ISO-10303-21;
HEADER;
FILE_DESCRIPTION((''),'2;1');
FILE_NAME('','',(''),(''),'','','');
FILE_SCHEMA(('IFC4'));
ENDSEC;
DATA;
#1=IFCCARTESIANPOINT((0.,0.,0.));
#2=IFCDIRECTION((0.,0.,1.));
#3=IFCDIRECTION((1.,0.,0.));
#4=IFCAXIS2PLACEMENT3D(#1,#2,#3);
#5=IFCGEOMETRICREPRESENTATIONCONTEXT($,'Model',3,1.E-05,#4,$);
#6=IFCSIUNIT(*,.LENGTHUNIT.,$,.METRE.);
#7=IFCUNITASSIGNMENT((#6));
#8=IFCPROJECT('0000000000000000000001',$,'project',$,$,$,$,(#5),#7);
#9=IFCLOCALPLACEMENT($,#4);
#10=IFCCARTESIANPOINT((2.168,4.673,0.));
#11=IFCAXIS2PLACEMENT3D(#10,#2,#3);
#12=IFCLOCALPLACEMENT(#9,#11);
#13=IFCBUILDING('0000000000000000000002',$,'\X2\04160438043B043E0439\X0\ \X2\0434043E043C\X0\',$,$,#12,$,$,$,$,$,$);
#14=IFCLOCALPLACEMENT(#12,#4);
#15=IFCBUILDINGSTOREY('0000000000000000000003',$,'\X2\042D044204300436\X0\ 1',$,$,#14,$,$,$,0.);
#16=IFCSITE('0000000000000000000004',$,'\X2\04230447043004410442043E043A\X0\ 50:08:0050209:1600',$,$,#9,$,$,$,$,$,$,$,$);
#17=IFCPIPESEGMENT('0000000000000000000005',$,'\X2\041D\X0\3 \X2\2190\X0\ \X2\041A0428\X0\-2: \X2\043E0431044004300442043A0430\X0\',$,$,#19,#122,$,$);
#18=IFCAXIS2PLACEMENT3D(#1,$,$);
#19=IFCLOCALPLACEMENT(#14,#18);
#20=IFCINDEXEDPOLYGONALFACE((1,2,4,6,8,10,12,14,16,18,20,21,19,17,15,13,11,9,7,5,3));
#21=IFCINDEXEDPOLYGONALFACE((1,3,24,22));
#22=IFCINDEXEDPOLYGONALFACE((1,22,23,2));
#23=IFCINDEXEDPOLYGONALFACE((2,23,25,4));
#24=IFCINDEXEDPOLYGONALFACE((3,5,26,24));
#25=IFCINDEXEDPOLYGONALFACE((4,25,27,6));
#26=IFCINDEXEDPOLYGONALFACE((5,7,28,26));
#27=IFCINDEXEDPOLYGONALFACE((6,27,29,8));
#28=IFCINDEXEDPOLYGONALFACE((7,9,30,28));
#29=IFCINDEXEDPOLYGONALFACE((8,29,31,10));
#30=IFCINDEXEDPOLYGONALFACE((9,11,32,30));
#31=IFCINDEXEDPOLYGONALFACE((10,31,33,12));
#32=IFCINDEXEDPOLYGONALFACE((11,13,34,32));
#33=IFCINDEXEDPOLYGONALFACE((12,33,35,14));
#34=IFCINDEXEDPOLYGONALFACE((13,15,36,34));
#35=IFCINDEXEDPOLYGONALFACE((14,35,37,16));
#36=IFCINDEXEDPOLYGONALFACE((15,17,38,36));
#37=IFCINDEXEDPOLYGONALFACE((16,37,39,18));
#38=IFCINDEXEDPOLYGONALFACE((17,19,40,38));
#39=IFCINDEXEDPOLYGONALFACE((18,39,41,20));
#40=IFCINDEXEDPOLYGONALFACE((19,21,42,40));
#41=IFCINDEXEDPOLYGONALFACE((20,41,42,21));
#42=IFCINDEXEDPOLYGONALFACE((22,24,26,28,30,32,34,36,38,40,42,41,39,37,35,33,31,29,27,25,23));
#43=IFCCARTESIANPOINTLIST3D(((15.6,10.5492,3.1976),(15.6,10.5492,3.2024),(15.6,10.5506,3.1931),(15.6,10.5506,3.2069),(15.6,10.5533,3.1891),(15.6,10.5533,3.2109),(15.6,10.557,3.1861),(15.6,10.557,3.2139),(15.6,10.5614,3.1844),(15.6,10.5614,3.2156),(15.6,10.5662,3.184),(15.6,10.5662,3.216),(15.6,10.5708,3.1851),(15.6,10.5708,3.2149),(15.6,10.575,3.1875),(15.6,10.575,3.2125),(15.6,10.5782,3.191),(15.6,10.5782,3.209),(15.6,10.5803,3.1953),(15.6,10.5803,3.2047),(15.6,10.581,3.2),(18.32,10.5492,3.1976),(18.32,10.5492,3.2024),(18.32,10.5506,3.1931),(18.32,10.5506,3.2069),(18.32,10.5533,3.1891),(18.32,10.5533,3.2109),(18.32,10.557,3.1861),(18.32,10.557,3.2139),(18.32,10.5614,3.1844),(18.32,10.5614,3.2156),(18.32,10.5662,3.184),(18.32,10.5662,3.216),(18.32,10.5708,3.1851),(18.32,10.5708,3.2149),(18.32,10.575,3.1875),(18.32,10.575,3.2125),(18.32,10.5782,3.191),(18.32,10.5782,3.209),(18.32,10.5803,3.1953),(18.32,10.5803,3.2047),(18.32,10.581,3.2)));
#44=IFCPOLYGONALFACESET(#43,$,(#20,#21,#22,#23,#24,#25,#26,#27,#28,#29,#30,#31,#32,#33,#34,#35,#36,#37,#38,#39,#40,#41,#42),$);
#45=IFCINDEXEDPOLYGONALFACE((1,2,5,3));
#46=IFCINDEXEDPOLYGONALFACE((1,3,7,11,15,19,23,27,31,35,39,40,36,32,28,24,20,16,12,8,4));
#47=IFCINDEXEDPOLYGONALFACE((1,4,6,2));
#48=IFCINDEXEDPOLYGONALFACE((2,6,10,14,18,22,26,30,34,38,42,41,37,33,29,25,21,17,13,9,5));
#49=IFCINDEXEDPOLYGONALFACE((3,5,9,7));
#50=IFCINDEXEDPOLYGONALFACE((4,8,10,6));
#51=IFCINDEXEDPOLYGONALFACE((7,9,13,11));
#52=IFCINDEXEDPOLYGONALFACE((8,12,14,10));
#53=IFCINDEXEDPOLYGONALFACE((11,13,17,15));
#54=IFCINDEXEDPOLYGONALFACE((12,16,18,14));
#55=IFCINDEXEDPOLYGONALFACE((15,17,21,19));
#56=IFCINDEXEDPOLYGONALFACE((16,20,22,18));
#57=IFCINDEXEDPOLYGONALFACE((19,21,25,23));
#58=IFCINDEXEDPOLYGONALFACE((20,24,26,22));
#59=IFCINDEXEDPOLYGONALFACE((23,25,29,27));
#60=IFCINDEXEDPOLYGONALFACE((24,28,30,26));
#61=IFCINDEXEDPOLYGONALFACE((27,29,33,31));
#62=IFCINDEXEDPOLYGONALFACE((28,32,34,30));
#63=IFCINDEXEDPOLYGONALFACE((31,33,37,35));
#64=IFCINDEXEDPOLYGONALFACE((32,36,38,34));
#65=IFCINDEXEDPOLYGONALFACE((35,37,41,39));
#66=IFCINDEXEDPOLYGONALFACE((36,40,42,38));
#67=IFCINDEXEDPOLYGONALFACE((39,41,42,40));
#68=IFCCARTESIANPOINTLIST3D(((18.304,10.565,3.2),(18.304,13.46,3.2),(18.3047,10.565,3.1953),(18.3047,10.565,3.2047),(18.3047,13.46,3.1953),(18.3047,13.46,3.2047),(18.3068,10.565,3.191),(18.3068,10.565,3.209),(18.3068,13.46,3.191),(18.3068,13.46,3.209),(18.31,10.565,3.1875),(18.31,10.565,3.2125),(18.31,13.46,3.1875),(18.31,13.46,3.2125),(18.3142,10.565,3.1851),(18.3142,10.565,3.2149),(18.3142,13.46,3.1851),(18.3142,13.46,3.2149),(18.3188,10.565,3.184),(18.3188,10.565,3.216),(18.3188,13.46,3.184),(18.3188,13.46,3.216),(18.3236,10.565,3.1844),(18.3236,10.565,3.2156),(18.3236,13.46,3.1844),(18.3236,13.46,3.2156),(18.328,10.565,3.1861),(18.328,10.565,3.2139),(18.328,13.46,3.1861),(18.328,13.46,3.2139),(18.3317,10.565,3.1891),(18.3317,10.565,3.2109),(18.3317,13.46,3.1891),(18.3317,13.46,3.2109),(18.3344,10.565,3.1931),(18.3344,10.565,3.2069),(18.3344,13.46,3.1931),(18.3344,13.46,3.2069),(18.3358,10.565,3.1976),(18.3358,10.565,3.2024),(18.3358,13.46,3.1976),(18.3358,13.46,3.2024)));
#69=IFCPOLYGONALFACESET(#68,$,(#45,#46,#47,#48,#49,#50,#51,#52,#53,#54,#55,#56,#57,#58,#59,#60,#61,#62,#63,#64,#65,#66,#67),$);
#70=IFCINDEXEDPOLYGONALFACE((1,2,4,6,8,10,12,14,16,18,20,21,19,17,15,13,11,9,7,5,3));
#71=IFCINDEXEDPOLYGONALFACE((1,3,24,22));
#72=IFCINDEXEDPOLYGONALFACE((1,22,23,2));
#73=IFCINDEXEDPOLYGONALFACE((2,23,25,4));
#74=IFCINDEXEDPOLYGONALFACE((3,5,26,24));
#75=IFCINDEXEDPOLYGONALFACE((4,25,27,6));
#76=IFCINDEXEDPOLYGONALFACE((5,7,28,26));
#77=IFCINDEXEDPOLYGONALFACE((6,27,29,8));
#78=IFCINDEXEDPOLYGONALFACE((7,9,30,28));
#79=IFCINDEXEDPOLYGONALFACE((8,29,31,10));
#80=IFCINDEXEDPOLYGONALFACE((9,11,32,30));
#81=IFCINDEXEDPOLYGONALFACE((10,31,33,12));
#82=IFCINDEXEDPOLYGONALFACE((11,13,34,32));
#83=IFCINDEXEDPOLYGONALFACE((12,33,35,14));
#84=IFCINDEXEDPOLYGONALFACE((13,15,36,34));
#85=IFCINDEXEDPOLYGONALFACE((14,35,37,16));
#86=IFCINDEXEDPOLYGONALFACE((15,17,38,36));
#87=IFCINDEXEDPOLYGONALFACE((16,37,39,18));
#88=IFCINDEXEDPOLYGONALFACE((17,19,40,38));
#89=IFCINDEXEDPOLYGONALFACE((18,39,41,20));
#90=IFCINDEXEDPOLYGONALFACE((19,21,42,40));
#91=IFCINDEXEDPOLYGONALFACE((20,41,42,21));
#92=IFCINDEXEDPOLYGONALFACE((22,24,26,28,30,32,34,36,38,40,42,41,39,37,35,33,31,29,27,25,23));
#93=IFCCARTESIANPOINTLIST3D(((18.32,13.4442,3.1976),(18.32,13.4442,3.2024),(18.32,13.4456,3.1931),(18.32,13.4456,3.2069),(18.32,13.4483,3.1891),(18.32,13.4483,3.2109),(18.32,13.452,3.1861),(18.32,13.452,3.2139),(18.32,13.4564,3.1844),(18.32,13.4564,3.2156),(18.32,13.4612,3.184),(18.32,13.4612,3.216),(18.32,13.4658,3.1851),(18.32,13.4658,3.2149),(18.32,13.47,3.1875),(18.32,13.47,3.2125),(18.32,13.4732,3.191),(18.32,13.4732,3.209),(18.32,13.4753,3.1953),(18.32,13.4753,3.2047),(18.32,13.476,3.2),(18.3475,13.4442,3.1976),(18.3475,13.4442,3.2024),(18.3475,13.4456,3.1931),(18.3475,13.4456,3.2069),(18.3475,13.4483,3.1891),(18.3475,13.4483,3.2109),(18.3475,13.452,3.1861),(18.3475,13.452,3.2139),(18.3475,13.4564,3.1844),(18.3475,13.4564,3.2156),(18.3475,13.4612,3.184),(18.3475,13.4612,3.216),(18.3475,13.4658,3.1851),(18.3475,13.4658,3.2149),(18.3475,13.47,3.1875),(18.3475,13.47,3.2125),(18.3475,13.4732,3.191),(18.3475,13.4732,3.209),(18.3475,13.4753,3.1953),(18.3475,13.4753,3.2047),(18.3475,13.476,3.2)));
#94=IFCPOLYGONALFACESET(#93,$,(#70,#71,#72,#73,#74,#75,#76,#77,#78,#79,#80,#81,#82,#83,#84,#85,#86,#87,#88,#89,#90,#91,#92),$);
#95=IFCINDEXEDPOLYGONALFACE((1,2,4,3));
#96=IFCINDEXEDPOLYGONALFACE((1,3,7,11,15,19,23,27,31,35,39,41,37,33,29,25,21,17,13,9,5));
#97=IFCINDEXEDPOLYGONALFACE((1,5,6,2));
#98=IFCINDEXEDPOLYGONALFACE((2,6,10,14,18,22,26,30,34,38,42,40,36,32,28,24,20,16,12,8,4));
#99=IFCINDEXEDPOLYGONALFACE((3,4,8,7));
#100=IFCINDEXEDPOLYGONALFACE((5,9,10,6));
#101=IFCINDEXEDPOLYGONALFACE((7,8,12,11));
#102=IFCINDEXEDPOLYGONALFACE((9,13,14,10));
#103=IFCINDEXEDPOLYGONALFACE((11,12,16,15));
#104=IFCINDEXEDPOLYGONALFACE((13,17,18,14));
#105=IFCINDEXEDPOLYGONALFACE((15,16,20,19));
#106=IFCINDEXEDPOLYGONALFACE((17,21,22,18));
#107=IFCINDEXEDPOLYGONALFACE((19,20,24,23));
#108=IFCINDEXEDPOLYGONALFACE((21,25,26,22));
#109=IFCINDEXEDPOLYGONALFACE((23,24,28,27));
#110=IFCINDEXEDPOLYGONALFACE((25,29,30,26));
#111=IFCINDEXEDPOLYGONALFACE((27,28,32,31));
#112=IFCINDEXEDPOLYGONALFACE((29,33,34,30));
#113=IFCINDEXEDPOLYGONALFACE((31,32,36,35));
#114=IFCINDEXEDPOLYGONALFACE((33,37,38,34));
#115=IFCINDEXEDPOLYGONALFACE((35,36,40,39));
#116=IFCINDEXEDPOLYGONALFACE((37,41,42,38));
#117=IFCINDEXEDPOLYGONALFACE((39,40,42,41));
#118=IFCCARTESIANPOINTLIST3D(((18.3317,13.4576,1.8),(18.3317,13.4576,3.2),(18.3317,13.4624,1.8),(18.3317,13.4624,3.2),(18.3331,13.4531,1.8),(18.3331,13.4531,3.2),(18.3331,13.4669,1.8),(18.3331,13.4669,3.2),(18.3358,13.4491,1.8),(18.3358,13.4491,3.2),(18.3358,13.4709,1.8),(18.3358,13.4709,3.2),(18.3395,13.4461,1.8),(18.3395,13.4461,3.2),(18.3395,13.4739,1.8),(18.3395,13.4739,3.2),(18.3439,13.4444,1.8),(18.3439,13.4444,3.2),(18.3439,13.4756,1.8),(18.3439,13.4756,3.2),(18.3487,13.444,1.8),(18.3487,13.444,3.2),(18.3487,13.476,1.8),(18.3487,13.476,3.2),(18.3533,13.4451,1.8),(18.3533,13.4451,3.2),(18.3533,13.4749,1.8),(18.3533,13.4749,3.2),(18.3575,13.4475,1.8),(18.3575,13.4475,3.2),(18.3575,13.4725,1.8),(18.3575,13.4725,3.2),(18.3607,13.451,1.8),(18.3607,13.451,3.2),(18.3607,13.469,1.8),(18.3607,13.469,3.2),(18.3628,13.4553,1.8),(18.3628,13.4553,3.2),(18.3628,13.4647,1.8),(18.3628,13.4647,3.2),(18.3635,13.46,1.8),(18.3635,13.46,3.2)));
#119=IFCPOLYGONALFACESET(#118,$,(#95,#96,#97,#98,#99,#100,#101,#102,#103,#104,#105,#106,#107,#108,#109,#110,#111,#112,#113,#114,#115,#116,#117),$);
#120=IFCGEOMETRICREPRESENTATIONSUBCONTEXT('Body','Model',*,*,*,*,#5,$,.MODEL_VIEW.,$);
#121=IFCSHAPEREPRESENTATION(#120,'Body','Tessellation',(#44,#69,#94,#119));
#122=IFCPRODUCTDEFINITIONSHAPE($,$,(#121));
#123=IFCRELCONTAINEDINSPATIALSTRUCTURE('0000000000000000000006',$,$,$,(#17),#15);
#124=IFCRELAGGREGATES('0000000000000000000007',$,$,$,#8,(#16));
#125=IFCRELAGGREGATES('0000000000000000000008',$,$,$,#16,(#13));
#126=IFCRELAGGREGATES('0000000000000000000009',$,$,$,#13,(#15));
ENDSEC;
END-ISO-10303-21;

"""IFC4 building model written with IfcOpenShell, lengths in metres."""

from ifc_helpers import new_model, si_unit, frame, origin_with_axes, origin_2d, place, context, subcontext, project, spatial, circle, extrude, element, save


model = new_model("IFC4")

# Units and contexts
model_context = context("Model", 3, precision=1e-05, world=origin_with_axes())
body_context = subcontext(model_context, "Body", "Model", "MODEL_VIEW")
ifc_project = project(units=[si_unit("LENGTHUNIT", "METRE")], contexts=[model_context])

# Site, building, storey
site_placement = place(None, origin_with_axes())
site = spatial("IfcSite", under=ifc_project, at=site_placement, Name="Участок 50:08:0050209:1600")
building_placement = place(site_placement, frame((2.168, 4.673, 0.0), z_axis=(0.0, 0.0, 1.0), x_axis=(1.0, 0.0, 0.0)))
building = spatial("IfcBuilding", under=site, at=building_placement, Name="Жилой дом")
storey_placement = place(building_placement, origin_with_axes())
storey = spatial("IfcBuildingStorey", under=building, at=storey_placement, Name="Этаж 1", Elevation=0.0)

# Pipe segment
pipe_segment_1_placement = place(storey_placement, origin_with_axes())
element("IfcPipeSegment", 1, at=pipe_segment_1_placement, inside=storey, Name="Н3 ← КШ-2: обратка", context=body_context, shape_type="SweptSolid", body=[
    extrude(circle(Radius=0.016, at=origin_2d()), frame((15.6, 10.565, 3.2), z_axis=(1.0, 0.0, 0.0), x_axis=(0.0, 1.0, 0.0)), (0.0, 0.0, 1.0), 2.72),
    extrude(circle(Radius=0.016, at=origin_2d()), frame((18.32, 10.565, 3.2), z_axis=(0.0, 1.0, 0.0), x_axis=(-1.0, 0.0, 0.0)), (0.0, 0.0, 1.0), 2.895),
    extrude(circle(Radius=0.016, at=origin_2d()), frame((18.32, 13.46, 3.2), z_axis=(1.0, 0.0, 0.0), x_axis=(0.0, 1.0, 0.0)), (0.0, 0.0, 1.0), 0.0275),
    extrude(circle(Radius=0.016, at=origin_2d()), frame((18.3475, 13.46, 3.2), z_axis=(0.0, 0.0, -1.0), x_axis=(1.0, 0.0, 0.0)), (0.0, 0.0, 1.0), 1.4),
])

save(model, "model.ifc")
